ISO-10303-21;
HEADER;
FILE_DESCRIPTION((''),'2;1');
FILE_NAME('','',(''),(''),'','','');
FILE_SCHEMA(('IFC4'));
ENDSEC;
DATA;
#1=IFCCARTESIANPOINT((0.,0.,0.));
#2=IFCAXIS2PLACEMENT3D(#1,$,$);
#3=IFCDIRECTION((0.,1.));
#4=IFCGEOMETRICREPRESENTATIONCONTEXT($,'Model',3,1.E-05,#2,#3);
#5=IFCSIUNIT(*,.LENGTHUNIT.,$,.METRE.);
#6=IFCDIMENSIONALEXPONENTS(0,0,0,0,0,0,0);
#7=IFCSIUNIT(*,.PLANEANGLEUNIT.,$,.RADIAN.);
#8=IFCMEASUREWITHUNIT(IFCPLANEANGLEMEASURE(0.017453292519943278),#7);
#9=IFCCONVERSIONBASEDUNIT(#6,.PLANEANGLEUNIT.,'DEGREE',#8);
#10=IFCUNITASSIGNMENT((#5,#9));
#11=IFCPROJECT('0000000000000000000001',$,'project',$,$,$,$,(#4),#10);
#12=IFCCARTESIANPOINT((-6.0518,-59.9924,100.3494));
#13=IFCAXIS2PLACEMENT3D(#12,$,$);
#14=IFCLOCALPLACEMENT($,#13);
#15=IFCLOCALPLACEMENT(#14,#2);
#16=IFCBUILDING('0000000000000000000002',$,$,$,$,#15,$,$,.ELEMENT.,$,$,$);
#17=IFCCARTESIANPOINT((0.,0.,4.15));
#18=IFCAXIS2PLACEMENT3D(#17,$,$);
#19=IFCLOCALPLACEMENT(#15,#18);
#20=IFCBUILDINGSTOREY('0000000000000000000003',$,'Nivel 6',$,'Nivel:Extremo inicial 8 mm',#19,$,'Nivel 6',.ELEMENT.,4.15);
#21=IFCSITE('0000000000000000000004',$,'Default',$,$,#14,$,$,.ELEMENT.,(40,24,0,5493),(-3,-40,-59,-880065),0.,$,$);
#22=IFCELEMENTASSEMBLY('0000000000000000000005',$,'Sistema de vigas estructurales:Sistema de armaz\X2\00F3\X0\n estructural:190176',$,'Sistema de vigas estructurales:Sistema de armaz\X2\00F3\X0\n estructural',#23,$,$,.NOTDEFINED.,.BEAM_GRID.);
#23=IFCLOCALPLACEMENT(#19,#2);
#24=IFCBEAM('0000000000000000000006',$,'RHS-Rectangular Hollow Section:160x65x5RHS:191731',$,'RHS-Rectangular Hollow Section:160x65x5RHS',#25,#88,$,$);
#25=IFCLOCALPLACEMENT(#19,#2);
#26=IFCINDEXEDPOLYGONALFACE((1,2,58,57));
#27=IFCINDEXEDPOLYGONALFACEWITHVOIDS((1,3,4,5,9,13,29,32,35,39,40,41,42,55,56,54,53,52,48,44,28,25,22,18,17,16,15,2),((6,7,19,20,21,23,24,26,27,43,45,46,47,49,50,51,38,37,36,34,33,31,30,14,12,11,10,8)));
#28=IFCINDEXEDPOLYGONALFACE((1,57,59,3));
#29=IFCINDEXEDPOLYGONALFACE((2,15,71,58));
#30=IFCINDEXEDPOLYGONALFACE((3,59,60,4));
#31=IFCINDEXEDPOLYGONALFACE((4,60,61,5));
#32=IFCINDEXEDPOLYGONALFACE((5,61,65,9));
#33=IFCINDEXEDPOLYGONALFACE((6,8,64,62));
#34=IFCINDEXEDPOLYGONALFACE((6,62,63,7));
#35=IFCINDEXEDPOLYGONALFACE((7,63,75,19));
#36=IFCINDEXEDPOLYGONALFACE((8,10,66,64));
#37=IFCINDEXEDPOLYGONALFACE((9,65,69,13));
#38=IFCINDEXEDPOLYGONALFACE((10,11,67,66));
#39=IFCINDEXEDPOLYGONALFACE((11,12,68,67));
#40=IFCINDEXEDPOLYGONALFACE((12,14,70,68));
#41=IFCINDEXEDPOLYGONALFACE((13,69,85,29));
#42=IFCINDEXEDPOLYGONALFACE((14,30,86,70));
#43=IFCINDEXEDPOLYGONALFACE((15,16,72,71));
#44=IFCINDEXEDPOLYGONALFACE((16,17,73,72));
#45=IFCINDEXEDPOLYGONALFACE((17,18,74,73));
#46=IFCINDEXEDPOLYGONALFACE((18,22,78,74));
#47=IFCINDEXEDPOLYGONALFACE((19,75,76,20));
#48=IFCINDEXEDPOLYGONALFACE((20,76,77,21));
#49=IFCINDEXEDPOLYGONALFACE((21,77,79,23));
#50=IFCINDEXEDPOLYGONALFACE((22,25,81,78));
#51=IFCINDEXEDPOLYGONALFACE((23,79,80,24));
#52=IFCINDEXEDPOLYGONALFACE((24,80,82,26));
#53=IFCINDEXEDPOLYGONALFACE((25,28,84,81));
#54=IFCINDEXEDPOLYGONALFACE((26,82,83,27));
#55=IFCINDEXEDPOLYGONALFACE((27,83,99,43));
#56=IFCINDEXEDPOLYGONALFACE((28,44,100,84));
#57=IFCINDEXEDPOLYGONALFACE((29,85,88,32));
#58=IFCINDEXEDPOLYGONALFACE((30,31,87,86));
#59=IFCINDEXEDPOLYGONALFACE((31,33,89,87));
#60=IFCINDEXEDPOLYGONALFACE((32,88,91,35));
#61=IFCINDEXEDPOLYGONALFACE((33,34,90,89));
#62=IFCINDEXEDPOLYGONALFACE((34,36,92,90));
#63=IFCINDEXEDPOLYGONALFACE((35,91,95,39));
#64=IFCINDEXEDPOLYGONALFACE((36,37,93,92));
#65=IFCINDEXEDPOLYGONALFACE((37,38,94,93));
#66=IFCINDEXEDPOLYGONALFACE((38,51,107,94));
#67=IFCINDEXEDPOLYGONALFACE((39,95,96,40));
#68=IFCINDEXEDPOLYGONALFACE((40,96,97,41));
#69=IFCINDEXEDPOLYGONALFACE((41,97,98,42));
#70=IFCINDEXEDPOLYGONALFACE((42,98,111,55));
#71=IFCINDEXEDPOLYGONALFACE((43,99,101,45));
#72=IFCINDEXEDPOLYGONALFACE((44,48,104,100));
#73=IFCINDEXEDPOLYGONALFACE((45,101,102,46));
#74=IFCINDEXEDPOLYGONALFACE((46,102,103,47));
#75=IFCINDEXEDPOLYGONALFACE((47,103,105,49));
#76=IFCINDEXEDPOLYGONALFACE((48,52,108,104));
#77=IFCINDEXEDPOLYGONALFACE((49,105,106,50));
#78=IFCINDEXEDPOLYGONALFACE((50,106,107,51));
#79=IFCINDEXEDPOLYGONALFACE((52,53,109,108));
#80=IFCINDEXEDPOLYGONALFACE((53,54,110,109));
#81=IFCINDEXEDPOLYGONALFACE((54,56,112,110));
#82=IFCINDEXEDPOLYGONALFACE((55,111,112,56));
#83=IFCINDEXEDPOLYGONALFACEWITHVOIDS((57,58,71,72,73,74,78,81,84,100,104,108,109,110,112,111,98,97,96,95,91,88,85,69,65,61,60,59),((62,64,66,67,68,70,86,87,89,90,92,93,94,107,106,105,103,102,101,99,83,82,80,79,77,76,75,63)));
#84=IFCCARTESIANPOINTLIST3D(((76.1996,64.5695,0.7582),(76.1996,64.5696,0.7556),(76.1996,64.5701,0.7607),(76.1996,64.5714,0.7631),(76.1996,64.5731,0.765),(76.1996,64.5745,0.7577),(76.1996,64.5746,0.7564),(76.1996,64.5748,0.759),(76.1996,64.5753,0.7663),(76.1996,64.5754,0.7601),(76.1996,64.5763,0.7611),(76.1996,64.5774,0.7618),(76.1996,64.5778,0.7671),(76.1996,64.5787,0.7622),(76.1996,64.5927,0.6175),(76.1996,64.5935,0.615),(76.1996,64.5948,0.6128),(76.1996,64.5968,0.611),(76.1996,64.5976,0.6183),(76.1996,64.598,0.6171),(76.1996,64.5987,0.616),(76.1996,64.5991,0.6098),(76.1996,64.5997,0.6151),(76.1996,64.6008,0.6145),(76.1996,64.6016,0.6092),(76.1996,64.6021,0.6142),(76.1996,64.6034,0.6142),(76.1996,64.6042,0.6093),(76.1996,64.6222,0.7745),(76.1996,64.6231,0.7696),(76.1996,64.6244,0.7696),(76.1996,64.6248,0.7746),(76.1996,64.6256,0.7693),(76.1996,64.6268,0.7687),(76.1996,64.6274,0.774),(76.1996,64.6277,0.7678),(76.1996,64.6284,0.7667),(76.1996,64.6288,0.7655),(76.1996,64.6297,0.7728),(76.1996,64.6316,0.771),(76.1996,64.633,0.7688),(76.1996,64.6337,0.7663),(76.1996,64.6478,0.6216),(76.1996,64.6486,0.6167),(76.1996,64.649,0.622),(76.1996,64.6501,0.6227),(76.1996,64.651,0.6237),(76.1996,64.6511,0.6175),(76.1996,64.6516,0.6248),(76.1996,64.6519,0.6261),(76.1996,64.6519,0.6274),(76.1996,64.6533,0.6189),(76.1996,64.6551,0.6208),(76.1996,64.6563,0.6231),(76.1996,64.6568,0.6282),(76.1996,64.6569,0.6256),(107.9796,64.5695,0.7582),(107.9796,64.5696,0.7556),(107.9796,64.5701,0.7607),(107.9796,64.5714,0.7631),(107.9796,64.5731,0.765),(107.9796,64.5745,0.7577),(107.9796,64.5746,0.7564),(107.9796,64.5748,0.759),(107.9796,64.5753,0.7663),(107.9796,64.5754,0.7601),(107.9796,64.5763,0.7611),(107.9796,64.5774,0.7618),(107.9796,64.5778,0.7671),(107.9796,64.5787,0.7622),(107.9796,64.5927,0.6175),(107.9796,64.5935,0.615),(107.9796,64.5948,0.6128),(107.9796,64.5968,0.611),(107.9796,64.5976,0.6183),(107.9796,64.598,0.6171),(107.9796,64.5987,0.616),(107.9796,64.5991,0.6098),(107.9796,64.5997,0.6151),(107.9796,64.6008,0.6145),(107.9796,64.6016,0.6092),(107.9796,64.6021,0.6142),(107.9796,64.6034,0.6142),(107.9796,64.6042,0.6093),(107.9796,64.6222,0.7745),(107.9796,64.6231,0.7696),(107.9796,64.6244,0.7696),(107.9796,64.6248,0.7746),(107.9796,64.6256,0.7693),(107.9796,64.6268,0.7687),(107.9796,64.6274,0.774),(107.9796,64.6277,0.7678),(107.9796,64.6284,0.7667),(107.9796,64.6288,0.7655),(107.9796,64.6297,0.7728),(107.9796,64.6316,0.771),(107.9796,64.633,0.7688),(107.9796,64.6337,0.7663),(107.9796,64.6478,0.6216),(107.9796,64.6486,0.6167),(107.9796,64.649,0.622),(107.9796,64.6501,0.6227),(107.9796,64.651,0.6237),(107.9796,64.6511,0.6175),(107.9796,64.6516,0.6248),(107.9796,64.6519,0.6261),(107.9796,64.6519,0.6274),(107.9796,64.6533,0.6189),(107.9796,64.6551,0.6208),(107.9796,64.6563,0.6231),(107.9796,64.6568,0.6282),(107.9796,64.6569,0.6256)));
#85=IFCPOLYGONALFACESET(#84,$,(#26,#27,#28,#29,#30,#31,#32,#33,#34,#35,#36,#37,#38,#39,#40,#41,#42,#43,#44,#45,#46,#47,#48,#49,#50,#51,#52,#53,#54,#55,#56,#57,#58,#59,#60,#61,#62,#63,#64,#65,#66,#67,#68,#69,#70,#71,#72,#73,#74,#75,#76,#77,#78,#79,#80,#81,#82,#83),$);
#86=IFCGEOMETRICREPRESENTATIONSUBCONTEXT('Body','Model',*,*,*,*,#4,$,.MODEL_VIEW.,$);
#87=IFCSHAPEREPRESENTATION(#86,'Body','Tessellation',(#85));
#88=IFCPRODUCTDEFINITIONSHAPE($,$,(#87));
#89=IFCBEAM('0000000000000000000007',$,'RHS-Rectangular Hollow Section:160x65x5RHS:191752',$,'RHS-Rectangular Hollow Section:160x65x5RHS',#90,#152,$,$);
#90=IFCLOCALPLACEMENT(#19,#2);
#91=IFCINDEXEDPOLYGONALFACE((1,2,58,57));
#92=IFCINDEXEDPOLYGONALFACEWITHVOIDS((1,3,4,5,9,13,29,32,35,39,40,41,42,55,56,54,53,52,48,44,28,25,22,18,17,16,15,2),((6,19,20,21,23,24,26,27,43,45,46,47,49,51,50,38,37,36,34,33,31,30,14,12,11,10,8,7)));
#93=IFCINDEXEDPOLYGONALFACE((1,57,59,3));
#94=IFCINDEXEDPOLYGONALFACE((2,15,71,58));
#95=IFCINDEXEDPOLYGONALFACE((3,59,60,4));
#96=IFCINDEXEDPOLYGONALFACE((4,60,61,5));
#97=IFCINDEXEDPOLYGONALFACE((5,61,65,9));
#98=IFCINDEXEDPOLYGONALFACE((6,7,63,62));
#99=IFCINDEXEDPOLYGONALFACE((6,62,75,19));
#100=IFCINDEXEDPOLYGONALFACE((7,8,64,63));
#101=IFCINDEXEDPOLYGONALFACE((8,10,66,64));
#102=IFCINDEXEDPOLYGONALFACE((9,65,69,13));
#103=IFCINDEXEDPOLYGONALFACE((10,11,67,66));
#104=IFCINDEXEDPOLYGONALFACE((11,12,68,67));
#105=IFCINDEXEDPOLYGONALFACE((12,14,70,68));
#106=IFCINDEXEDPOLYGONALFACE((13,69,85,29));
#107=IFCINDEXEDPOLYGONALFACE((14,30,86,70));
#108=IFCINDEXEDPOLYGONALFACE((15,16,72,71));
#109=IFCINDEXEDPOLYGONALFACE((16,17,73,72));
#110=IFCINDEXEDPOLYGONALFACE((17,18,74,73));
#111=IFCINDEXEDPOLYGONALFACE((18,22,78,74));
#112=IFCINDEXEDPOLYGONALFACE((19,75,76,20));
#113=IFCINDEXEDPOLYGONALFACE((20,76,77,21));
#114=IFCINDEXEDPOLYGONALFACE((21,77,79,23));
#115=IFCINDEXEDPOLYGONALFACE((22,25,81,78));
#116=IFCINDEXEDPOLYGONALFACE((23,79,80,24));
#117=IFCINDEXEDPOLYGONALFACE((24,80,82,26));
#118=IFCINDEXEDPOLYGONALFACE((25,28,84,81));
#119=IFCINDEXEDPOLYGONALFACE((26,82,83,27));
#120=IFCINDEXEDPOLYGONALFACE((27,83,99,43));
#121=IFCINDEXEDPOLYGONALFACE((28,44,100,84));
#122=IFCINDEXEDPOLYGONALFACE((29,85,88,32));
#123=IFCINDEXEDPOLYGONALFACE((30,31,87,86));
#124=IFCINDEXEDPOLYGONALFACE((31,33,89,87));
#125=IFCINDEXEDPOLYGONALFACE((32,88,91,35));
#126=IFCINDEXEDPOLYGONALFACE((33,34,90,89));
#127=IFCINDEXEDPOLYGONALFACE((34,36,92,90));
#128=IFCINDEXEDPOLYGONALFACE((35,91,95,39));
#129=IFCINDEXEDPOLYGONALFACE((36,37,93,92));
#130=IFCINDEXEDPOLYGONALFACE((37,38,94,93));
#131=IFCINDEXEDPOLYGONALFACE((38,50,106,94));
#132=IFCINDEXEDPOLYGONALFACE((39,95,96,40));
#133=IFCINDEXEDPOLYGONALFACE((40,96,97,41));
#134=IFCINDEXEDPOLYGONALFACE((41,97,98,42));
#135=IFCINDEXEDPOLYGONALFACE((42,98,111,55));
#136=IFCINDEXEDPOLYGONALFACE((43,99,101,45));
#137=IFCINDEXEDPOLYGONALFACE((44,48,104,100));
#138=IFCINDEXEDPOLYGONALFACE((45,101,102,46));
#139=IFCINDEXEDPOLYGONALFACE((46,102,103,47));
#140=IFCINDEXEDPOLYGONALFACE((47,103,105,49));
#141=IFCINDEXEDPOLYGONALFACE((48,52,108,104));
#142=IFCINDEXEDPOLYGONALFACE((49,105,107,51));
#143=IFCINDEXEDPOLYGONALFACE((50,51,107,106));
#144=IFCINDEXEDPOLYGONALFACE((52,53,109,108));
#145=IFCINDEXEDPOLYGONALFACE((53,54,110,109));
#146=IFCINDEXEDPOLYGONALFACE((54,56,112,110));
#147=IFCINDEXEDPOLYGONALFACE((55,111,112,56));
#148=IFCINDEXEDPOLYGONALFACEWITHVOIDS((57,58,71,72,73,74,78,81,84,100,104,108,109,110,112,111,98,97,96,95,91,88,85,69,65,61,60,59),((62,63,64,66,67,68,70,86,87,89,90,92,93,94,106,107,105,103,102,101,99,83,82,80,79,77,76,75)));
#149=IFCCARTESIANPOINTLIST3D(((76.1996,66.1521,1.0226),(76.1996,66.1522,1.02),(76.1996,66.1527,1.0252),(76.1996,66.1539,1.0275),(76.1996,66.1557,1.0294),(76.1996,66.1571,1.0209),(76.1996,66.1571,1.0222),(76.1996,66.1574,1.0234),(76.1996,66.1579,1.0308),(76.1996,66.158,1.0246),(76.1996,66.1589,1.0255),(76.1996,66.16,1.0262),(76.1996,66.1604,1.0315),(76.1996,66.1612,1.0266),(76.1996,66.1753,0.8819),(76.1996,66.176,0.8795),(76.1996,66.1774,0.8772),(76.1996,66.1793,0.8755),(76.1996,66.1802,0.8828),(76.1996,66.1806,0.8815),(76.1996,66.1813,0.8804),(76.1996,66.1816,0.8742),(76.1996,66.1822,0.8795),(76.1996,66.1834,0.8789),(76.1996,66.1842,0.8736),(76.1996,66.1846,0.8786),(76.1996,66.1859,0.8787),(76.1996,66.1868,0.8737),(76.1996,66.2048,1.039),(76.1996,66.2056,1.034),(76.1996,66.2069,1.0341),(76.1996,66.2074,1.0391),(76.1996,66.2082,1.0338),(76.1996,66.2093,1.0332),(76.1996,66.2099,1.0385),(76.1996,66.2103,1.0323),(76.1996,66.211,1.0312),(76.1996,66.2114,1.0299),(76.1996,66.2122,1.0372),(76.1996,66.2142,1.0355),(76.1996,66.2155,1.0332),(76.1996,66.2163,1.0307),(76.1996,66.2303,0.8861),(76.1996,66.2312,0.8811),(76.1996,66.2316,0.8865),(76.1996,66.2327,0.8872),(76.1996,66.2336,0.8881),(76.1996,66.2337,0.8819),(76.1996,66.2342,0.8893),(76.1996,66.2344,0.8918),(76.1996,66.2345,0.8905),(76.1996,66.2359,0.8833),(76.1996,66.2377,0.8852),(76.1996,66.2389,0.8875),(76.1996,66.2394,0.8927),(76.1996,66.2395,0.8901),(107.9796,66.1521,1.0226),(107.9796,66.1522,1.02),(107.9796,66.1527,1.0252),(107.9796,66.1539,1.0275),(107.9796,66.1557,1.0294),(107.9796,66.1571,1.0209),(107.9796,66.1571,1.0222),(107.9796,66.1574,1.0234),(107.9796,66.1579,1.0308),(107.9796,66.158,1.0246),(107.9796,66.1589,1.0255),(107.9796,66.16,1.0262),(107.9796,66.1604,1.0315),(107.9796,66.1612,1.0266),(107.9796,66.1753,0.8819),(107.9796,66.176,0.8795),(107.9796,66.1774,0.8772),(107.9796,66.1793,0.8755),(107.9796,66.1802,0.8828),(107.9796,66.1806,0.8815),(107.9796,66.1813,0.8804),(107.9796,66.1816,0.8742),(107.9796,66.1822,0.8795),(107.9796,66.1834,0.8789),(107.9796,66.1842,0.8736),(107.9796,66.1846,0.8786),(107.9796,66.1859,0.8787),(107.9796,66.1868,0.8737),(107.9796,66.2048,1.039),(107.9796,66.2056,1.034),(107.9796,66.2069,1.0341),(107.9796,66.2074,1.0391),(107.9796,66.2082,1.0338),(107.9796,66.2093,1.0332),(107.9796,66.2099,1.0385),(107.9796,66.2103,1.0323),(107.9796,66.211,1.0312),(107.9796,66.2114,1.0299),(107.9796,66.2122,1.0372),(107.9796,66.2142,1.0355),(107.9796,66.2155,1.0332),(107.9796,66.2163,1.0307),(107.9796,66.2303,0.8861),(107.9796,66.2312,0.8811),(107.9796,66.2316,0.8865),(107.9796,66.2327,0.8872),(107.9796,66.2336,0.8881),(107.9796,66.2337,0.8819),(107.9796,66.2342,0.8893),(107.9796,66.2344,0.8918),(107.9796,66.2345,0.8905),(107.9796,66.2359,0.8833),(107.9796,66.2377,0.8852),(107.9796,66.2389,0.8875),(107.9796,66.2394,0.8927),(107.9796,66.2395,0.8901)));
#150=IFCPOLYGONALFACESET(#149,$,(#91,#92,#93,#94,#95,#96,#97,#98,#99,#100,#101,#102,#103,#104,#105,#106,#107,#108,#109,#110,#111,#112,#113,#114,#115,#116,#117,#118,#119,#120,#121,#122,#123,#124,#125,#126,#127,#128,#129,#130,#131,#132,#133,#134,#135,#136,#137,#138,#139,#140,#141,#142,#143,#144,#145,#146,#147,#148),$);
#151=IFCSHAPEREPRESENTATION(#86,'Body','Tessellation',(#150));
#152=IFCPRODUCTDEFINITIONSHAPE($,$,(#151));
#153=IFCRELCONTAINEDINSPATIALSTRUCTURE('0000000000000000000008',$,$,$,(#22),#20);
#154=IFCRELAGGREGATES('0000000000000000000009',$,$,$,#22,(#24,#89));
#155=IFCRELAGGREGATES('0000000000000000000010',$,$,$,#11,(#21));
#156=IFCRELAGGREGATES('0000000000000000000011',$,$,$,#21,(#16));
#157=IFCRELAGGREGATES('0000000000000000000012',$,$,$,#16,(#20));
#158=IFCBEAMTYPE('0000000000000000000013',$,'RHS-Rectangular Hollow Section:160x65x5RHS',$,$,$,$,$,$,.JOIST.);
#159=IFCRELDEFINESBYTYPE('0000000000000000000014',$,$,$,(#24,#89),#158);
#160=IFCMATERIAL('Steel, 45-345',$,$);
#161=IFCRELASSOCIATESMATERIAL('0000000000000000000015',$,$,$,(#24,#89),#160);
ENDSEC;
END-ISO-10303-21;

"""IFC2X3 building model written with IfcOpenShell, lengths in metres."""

from ifc_helpers import new_model, entity, si_unit, converted_unit, direction, frame, frame_2d, origin, place, context, subcontext, project, spatial, polyline, circle_curve, parameter, trimmed, segment, composite_curve, outline, extrude, material, type_object, element, aggregate, save


model = new_model("IFC2X3")

# Units and contexts
model_context = context("Model", 3, precision=1e-05, world=origin(), true_north=direction((0.0, 1.0)))
body_context = subcontext(model_context, "Body", "Model", "MODEL_VIEW")
ifc_project = project(units=[si_unit("LENGTHUNIT", "METRE"), converted_unit("PLANEANGLEUNIT", "DEGREE", entity("IfcPlaneAngleMeasure", 0.017453292519943278), si_unit("PLANEANGLEUNIT", "RADIAN"), dimensions=[0, 0, 0, 0, 0, 0, 0])], contexts=[model_context])

# Site, building, storey
site_placement = place(None, frame((-6.0518, -59.9924, 100.3494)))
site = spatial("IfcSite", under=ifc_project, at=site_placement, Name="Default", CompositionType="ELEMENT", RefLatitude=(40, 24, 0, 5493), RefLongitude=(-3, -40, -59, -880065), RefElevation=0.0)
building_placement = place(site_placement, origin())
building = spatial("IfcBuilding", under=site, at=building_placement, CompositionType="ELEMENT")
storey_placement = place(building_placement, frame((0.0, 0.0, 4.15)))
storey = spatial("IfcBuildingStorey", under=building, at=storey_placement, Name="Nivel 6", ObjectType="Nivel:Extremo inicial 8 mm", LongName="Nivel 6", CompositionType="ELEMENT", Elevation=4.15)

# Shared definitions
ifc_material_1 = material(Name="Steel, 45-345")

# Element assembly, beams
assembly_placement = place(storey_placement, origin())
assembly = element("IfcElementAssembly", 1, at=assembly_placement, inside=storey, Name="Sistema de vigas estructurales:Sistema de armazón estructural:190176", ObjectType="Sistema de vigas estructurales:Sistema de armazón estructural", AssemblyPlace="NOTDEFINED", PredefinedType="BEAM_GRID")
beam_type_1 = type_object("IfcBeamType", Name="RHS-Rectangular Hollow Section:160x65x5RHS", PredefinedType="JOIST")
beam_1_placement = place(assembly_placement, frame((76.1996, 64.6528, 0.4552)))
beam_1 = element("IfcBeam", 2, at=beam_1_placement, type_object=beam_type_1, material=ifc_material_1, Name="RHS-Rectangular Hollow Section:160x65x5RHS:191731", ObjectType="RHS-Rectangular Hollow Section:160x65x5RHS", context=body_context, shape_type="SweptSolid", body=[
    extrude(outline(composite_curve([segment(trimmed(circle_curve(frame_2d((-0.0225, -0.07), x_axis=(1.0, 0.0)), 0.01), [parameter(180.0)], [parameter(270.0)], True, "PARAMETER"), True, "CONTINUOUS"), segment(polyline([(-0.0225, -0.08), (0.0225, -0.08)]), True, "CONTINUOUS"), segment(trimmed(circle_curve(frame_2d((0.0225, -0.07), x_axis=(1.0, 0.0)), 0.01), [parameter(270.0)], [parameter(0.0)], True, "PARAMETER"), True, "CONTINUOUS"), segment(polyline([(0.0325, -0.07), (0.0325, 0.07)]), True, "CONTINUOUS"), segment(trimmed(circle_curve(frame_2d((0.0225, 0.07), x_axis=(1.0, 0.0)), 0.01), [parameter(360.0)], [parameter(90.0)], True, "PARAMETER"), True, "CONTINUOUS"), segment(polyline([(0.0225, 0.08), (-0.0225, 0.08)]), True, "CONTINUOUS"), segment(trimmed(circle_curve(frame_2d((-0.0225, 0.07), x_axis=(1.0, 0.0)), 0.01), [parameter(90.0)], [parameter(180.0)], True, "PARAMETER"), True, "CONTINUOUS"), segment(polyline([(-0.0325, 0.07), (-0.0325, -0.07)]), True, "CONTINUOUS")], self_intersect=False), holes=[composite_curve([segment(polyline([(0.0225, -0.075), (-0.0225, -0.075)]), True, "CONTINUOUS"), segment(trimmed(circle_curve(frame_2d((-0.0225, -0.07), x_axis=(1.0, 0.0)), 0.005), [parameter(180.0)], [parameter(270.0)], True, "PARAMETER"), False, "CONTINUOUS"), segment(polyline([(-0.0275, -0.07), (-0.0275, 0.07)]), True, "CONTINUOUS"), segment(trimmed(circle_curve(frame_2d((-0.0225, 0.07), x_axis=(1.0, 0.0)), 0.005), [parameter(90.0)], [parameter(180.0)], True, "PARAMETER"), False, "CONTINUOUS"), segment(polyline([(-0.0225, 0.075), (0.0225, 0.075)]), True, "CONTINUOUS"), segment(trimmed(circle_curve(frame_2d((0.0225, 0.07), x_axis=(1.0, 0.0)), 0.005), [parameter(0.0)], [parameter(90.0)], True, "PARAMETER"), False, "CONTINUOUS"), segment(polyline([(0.0275, 0.07), (0.0275, -0.07)]), True, "CONTINUOUS"), segment(trimmed(circle_curve(frame_2d((0.0225, -0.07), x_axis=(1.0, 0.0)), 0.005), [parameter(270.0)], [parameter(0.0)], True, "PARAMETER"), False, "CONTINUOUS")], self_intersect=False)]), frame((0.0, -0.0396, 0.2367), z_axis=(1.0, 0.0, 0.0), x_axis=(0.0, -0.986325, -0.16481)), (0.0, 0.0, 1.0), 31.78),
])
beam_2_placement = place(assembly_placement, frame((76.1996, 66.2353, 0.7196)))
beam_2 = element("IfcBeam", 3, at=beam_2_placement, type_object=beam_type_1, material=ifc_material_1, Name="RHS-Rectangular Hollow Section:160x65x5RHS:191752", ObjectType="RHS-Rectangular Hollow Section:160x65x5RHS", context=body_context, shape_type="SweptSolid", body=[
    extrude(outline(composite_curve([segment(trimmed(circle_curve(frame_2d((-0.0225, -0.07), x_axis=(1.0, 0.0)), 0.01), [parameter(180.0)], [parameter(270.0)], True, "PARAMETER"), True, "CONTINUOUS"), segment(polyline([(-0.0225, -0.08), (0.0225, -0.08)]), True, "CONTINUOUS"), segment(trimmed(circle_curve(frame_2d((0.0225, -0.07), x_axis=(1.0, 0.0)), 0.01), [parameter(270.0)], [parameter(0.0)], True, "PARAMETER"), True, "CONTINUOUS"), segment(polyline([(0.0325, -0.07), (0.0325, 0.07)]), True, "CONTINUOUS"), segment(trimmed(circle_curve(frame_2d((0.0225, 0.07), x_axis=(1.0, 0.0)), 0.01), [parameter(360.0)], [parameter(90.0)], True, "PARAMETER"), True, "CONTINUOUS"), segment(polyline([(0.0225, 0.08), (-0.0225, 0.08)]), True, "CONTINUOUS"), segment(trimmed(circle_curve(frame_2d((-0.0225, 0.07), x_axis=(1.0, 0.0)), 0.01), [parameter(90.0)], [parameter(180.0)], True, "PARAMETER"), True, "CONTINUOUS"), segment(polyline([(-0.0325, 0.07), (-0.0325, -0.07)]), True, "CONTINUOUS")], self_intersect=False), holes=[composite_curve([segment(polyline([(0.0225, -0.075), (-0.0225, -0.075)]), True, "CONTINUOUS"), segment(trimmed(circle_curve(frame_2d((-0.0225, -0.07), x_axis=(1.0, 0.0)), 0.005), [parameter(180.0)], [parameter(270.0)], True, "PARAMETER"), False, "CONTINUOUS"), segment(polyline([(-0.0275, -0.07), (-0.0275, 0.07)]), True, "CONTINUOUS"), segment(trimmed(circle_curve(frame_2d((-0.0225, 0.07), x_axis=(1.0, 0.0)), 0.005), [parameter(90.0)], [parameter(180.0)], True, "PARAMETER"), False, "CONTINUOUS"), segment(polyline([(-0.0225, 0.075), (0.0225, 0.075)]), True, "CONTINUOUS"), segment(trimmed(circle_curve(frame_2d((0.0225, 0.07), x_axis=(1.0, 0.0)), 0.005), [parameter(0.0)], [parameter(90.0)], True, "PARAMETER"), False, "CONTINUOUS"), segment(polyline([(0.0275, 0.07), (0.0275, -0.07)]), True, "CONTINUOUS"), segment(trimmed(circle_curve(frame_2d((0.0225, -0.07), x_axis=(1.0, 0.0)), 0.005), [parameter(270.0)], [parameter(0.0)], True, "PARAMETER"), False, "CONTINUOUS")], self_intersect=False)]), frame((0.0, -0.0396, 0.2367), z_axis=(1.0, 0.0, 0.0), x_axis=(0.0, -0.986325, -0.16481)), (0.0, 0.0, 1.0), 31.78),
])
aggregate(assembly, [beam_1, beam_2])

save(model, "model.ifc")
